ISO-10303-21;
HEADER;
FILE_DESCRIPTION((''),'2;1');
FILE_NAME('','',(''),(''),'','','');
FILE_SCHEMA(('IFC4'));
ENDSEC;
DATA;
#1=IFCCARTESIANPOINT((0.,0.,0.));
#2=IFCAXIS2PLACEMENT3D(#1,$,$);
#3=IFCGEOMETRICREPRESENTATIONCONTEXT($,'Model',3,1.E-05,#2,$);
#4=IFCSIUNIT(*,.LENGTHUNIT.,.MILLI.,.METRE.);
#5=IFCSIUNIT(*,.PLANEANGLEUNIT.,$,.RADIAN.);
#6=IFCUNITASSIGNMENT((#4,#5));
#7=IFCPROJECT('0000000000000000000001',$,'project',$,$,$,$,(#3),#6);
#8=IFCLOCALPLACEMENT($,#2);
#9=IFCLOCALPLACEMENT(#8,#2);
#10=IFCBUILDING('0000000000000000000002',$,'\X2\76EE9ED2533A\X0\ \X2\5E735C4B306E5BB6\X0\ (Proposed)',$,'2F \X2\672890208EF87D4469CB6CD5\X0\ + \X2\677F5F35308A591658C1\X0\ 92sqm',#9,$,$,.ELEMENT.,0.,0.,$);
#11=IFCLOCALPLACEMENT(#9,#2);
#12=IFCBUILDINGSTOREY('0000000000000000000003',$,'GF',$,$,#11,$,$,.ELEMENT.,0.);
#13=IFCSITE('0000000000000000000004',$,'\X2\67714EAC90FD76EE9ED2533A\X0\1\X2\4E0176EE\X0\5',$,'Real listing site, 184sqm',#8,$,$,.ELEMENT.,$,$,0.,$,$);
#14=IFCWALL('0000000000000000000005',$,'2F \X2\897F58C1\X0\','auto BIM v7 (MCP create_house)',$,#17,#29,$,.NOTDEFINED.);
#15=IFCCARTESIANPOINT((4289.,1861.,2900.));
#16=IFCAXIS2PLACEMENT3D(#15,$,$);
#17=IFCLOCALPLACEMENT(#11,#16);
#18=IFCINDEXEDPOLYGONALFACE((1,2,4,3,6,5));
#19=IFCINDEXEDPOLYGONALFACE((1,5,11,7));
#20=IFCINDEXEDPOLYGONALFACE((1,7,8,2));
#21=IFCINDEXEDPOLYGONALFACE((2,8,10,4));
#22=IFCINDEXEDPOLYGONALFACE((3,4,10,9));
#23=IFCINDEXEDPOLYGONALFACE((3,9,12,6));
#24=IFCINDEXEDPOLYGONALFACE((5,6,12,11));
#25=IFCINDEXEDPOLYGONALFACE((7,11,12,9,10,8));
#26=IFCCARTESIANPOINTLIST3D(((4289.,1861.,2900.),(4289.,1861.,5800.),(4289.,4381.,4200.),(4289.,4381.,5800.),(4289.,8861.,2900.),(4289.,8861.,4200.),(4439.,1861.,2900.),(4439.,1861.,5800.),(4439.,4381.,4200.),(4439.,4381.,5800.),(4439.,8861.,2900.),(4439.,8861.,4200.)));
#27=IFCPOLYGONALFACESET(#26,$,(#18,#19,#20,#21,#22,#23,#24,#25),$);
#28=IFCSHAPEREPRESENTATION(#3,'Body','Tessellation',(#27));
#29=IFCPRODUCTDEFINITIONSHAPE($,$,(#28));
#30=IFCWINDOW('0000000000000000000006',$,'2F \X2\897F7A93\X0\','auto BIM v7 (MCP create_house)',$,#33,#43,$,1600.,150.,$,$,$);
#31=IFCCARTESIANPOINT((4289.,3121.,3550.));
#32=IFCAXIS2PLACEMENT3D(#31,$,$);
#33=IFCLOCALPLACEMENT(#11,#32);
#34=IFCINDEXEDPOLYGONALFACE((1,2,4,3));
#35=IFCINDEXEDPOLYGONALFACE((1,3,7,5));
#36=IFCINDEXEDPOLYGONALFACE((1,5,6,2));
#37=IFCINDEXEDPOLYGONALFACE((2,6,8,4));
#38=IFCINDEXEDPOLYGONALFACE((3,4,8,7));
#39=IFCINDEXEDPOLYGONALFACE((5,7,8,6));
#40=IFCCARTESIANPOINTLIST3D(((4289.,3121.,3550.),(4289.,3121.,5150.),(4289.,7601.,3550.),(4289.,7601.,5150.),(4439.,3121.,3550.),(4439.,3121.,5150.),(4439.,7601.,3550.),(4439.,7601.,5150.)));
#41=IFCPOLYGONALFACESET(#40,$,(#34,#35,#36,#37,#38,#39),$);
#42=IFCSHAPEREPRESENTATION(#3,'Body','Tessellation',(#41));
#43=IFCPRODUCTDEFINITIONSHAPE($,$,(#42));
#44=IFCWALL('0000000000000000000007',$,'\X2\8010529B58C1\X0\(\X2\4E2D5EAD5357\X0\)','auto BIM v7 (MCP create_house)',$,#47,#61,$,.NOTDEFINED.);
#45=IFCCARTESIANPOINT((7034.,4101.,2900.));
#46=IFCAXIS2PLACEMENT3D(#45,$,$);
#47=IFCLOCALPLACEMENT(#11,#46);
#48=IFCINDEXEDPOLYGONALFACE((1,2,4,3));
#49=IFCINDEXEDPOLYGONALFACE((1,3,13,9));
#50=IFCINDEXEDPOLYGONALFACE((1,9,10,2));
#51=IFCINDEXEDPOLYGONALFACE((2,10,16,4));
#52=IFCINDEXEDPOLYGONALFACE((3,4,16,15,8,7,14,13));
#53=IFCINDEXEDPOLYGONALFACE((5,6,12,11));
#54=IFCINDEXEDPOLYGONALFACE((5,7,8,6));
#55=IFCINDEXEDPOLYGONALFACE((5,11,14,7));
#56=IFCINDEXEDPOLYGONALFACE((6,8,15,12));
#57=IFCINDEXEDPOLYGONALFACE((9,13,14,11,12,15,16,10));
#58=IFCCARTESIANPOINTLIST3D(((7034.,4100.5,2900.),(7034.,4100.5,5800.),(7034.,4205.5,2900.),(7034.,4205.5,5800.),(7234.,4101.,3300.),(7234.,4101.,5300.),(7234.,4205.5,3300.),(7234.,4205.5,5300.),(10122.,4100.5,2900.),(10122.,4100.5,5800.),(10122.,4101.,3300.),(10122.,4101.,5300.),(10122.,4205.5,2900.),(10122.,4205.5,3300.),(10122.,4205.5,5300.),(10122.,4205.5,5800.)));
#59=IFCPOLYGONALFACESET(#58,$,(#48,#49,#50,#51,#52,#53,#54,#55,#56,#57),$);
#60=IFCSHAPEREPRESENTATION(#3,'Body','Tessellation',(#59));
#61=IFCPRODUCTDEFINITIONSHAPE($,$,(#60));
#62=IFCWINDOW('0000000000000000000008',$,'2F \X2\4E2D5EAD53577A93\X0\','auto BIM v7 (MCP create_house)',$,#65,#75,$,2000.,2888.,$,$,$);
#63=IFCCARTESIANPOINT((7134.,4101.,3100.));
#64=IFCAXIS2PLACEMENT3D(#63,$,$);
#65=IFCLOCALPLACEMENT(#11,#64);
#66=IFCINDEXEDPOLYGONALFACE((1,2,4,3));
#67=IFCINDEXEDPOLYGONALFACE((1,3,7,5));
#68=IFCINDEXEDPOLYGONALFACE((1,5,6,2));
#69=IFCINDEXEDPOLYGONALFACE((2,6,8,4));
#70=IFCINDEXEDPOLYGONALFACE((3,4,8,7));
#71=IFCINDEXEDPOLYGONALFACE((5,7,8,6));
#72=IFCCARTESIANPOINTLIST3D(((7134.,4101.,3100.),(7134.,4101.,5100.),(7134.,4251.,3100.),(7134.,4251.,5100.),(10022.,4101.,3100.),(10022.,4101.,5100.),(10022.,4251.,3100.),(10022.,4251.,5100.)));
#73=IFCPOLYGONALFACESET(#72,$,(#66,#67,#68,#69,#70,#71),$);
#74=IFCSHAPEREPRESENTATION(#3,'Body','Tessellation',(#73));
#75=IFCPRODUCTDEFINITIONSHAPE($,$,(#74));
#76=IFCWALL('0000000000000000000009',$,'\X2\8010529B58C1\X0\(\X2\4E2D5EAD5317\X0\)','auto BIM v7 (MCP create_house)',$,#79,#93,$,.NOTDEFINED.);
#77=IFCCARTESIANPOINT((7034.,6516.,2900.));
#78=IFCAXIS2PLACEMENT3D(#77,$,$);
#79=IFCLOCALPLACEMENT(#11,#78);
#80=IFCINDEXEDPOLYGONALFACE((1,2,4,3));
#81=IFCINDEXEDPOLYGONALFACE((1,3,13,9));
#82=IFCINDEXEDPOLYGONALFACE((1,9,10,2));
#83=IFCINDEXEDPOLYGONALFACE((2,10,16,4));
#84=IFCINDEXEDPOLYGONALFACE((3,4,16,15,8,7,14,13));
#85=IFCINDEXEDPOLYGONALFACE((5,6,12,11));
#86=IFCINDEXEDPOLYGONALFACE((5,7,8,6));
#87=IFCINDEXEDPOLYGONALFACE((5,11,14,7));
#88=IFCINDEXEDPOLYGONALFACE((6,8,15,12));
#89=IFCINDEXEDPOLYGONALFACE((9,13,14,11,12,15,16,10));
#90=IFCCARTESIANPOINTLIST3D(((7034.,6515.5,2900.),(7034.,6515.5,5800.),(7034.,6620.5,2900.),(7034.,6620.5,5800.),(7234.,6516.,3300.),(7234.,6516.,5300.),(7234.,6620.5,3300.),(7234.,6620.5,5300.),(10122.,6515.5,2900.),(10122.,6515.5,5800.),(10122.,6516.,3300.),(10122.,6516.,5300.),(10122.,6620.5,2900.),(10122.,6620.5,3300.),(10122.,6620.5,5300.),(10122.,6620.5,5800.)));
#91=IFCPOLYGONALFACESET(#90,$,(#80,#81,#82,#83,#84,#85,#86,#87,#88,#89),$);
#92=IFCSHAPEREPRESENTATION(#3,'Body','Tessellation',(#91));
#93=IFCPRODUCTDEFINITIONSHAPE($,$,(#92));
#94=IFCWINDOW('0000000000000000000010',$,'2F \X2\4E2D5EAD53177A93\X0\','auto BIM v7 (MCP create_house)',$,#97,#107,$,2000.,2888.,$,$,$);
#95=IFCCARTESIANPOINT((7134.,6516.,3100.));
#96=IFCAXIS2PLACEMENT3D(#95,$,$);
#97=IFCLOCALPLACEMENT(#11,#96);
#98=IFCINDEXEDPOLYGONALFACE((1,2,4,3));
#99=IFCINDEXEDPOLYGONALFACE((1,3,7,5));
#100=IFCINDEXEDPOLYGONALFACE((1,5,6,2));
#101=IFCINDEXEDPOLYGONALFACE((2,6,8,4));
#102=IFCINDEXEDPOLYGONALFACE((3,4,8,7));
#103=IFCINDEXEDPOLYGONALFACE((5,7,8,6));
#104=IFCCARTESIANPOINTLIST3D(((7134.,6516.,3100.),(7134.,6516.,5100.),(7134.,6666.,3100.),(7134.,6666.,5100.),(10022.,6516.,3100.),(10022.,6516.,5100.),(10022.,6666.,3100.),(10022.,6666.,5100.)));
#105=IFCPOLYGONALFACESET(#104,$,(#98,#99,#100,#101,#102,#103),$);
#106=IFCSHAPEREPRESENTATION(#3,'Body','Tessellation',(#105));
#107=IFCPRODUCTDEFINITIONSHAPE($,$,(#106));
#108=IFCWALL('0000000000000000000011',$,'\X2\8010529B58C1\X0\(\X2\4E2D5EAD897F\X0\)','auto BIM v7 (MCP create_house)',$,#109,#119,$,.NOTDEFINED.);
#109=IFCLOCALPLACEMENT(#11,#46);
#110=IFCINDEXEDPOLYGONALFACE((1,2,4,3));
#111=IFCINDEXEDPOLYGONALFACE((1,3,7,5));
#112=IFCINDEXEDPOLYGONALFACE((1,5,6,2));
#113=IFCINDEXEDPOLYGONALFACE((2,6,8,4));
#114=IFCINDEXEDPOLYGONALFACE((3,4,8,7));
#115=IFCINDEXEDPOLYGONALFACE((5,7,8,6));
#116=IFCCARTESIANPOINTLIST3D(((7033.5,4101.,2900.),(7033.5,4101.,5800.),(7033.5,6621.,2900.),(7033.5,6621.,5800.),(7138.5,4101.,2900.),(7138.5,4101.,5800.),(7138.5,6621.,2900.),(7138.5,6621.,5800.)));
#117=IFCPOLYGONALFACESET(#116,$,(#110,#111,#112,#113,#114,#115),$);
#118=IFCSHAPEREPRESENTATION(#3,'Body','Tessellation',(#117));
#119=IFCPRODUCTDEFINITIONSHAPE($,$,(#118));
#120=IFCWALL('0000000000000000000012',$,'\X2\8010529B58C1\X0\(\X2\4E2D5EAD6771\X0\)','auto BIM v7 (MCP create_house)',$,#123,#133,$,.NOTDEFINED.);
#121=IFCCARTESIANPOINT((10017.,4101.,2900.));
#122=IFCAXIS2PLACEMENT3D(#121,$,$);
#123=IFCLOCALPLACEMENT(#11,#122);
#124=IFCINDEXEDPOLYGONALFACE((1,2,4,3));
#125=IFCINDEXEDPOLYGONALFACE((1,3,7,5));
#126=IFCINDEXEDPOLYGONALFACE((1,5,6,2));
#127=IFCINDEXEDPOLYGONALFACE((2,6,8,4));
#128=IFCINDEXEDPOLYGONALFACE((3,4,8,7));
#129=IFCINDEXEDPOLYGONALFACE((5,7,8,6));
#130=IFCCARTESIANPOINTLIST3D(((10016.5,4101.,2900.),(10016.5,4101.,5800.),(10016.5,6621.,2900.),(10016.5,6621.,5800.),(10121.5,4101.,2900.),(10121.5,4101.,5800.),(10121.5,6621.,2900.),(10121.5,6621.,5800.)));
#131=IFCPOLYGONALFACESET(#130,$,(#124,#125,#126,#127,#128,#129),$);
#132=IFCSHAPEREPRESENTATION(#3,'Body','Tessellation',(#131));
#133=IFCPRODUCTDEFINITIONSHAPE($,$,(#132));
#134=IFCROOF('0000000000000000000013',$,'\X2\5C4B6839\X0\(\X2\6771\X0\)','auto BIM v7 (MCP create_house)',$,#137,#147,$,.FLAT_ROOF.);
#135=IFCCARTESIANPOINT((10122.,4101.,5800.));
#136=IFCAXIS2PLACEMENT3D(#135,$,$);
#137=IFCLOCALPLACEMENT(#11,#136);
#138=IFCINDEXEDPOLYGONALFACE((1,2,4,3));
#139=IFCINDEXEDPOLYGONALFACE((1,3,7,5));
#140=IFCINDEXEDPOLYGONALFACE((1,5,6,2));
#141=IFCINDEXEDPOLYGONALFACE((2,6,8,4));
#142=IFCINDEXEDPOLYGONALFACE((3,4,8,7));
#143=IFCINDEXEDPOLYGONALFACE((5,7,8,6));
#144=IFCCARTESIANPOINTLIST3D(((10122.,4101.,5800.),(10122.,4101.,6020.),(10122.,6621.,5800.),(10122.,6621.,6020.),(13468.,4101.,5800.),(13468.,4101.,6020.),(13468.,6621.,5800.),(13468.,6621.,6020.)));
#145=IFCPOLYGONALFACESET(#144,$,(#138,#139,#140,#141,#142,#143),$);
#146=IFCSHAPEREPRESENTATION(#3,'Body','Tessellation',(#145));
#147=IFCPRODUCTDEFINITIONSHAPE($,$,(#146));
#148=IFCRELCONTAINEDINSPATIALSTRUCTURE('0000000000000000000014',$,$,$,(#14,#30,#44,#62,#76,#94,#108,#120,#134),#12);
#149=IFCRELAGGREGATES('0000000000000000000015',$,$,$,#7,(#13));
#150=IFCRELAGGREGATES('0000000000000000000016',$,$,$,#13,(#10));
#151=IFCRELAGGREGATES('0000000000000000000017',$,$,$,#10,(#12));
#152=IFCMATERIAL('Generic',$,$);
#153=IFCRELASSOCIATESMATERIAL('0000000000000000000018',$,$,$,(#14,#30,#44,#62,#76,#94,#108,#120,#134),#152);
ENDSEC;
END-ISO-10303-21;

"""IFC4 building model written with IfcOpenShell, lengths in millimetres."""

from ifc_helpers import new_model, si_unit, frame, frame_2d, origin, place, context, project, spatial, rectangle, extrude, material, element, fill, save


model = new_model("IFC4")

# Units and contexts
model_context = context("Model", 3, precision=1e-05, world=origin())
ifc_project = project(units=[si_unit("LENGTHUNIT", "METRE", prefix="MILLI"), si_unit("PLANEANGLEUNIT", "RADIAN")], contexts=[model_context])

# Site, building, storey
site_placement = place(None, origin())
site = spatial("IfcSite", under=ifc_project, at=site_placement, Name="東京都目黒区1丁目5", ObjectType="Real listing site, 184sqm", CompositionType="ELEMENT", RefElevation=0.0)
building_placement = place(site_placement, origin())
building = spatial("IfcBuilding", under=site, at=building_placement, Name="目黒区 平屋の家 (Proposed)", ObjectType="2F 木造軸組構法 + 板張り外壁 92sqm", CompositionType="ELEMENT", ElevationOfRefHeight=0.0, ElevationOfTerrain=0.0)
storey_placement = place(building_placement, origin())
storey = spatial("IfcBuildingStorey", under=building, at=storey_placement, Name="GF", CompositionType="ELEMENT", Elevation=0.0)

# Shared definitions
ifc_material = material(Name="Generic")

# Walls, openings, windows
wall_1_placement = place(storey_placement, frame((4289.0, 1861.0, 2900.0)))
wall_1 = element("IfcWall", 1, at=wall_1_placement, inside=storey, material=ifc_material, Name="2F 西壁", Description="auto BIM v7 (MCP create_house)", PredefinedType="NOTDEFINED", context=model_context, shape_type="SweptSolid", body=[
    extrude(rectangle(XDim=150.0, YDim=7000.0, at=frame_2d((75.0, 3500.0))), frame((4289.0, 1861.0, 2900.0)), (0.0, 0.0, 1.0), 2900.0),
])
opening_1_placement = place(storey_placement, frame((4289.0, 3121.0, 3550.0)))
opening_1 = element("IfcOpeningElement", 2, at=opening_1_placement, cuts=wall_1, PredefinedType="NOTDEFINED", context=model_context, shape_type="SweptSolid", body=[
    extrude(rectangle(XDim=150.0, YDim=4480.0, at=frame_2d((75.0, 2240.0))), frame((4289.0, 3121.0, 3550.0)), (0.0, 0.0, 1.0), 1600.0),
])
window_1_placement = place(storey_placement, frame((4289.0, 3121.0, 3550.0)))
window_1 = element("IfcWindow", 3, at=window_1_placement, inside=storey, material=ifc_material, Name="2F 西窓", Description="auto BIM v7 (MCP create_house)", OverallHeight=1600.0, OverallWidth=150.0, context=model_context, shape_type="SweptSolid", body=[
    extrude(rectangle(XDim=150.0, YDim=4480.0, at=frame_2d((75.0, 2240.0))), frame((4289.0, 3121.0, 3550.0)), (0.0, 0.0, 1.0), 1600.0),
])
fill(opening_1, window_1)
wall_2_placement = place(storey_placement, frame((7034.0, 4101.0, 2900.0)))
wall_2 = element("IfcWall", 4, at=wall_2_placement, inside=storey, material=ifc_material, Name="耐力壁(中庭南)", Description="auto BIM v7 (MCP create_house)", PredefinedType="NOTDEFINED", context=model_context, shape_type="SweptSolid", body=[
    extrude(rectangle(XDim=3088.0, YDim=105.0, at=frame_2d((1544.0, 52.0))), frame((7034.0, 4101.0, 2900.0)), (0.0, 0.0, 1.0), 2900.0),
])
opening_2_placement = place(storey_placement, frame((7134.0, 4101.0, 3100.0)))
opening_2 = element("IfcOpeningElement", 5, at=opening_2_placement, cuts=wall_2, PredefinedType="NOTDEFINED", context=model_context, shape_type="SweptSolid", body=[
    extrude(rectangle(XDim=2888.0, YDim=150.0, at=frame_2d((1444.0, 75.0))), frame((7134.0, 4101.0, 3100.0)), (0.0, 0.0, 1.0), 2000.0),
])
window_2_placement = place(storey_placement, frame((7134.0, 4101.0, 3100.0)))
window_2 = element("IfcWindow", 6, at=window_2_placement, inside=storey, material=ifc_material, Name="2F 中庭南窓", Description="auto BIM v7 (MCP create_house)", OverallHeight=2000.0, OverallWidth=2888.0, context=model_context, shape_type="SweptSolid", body=[
    extrude(rectangle(XDim=2888.0, YDim=150.0, at=frame_2d((1444.0, 75.0))), frame((7134.0, 4101.0, 3100.0)), (0.0, 0.0, 1.0), 2000.0),
])
fill(opening_2, window_2)
wall_3_placement = place(storey_placement, frame((7034.0, 6516.0, 2900.0)))
wall_3 = element("IfcWall", 7, at=wall_3_placement, inside=storey, material=ifc_material, Name="耐力壁(中庭北)", Description="auto BIM v7 (MCP create_house)", PredefinedType="NOTDEFINED", context=model_context, shape_type="SweptSolid", body=[
    extrude(rectangle(XDim=3088.0, YDim=105.0, at=frame_2d((1544.0, 52.0))), frame((7034.0, 6516.0, 2900.0)), (0.0, 0.0, 1.0), 2900.0),
])
opening_3_placement = place(storey_placement, frame((7134.0, 6516.0, 3100.0)))
opening_3 = element("IfcOpeningElement", 8, at=opening_3_placement, cuts=wall_3, PredefinedType="NOTDEFINED", context=model_context, shape_type="SweptSolid", body=[
    extrude(rectangle(XDim=2888.0, YDim=150.0, at=frame_2d((1444.0, 75.0))), frame((7134.0, 6516.0, 3100.0)), (0.0, 0.0, 1.0), 2000.0),
])
window_3_placement = place(storey_placement, frame((7134.0, 6516.0, 3100.0)))
window_3 = element("IfcWindow", 9, at=window_3_placement, inside=storey, material=ifc_material, Name="2F 中庭北窓", Description="auto BIM v7 (MCP create_house)", OverallHeight=2000.0, OverallWidth=2888.0, context=model_context, shape_type="SweptSolid", body=[
    extrude(rectangle(XDim=2888.0, YDim=150.0, at=frame_2d((1444.0, 75.0))), frame((7134.0, 6516.0, 3100.0)), (0.0, 0.0, 1.0), 2000.0),
])
fill(opening_3, window_3)

# Walls
wall_4_placement = place(storey_placement, frame((7034.0, 4101.0, 2900.0)))
element("IfcWall", 10, at=wall_4_placement, inside=storey, material=ifc_material, Name="耐力壁(中庭西)", Description="auto BIM v7 (MCP create_house)", PredefinedType="NOTDEFINED", context=model_context, shape_type="SweptSolid", body=[
    extrude(rectangle(XDim=105.0, YDim=2520.0, at=frame_2d((52.0, 1260.0))), frame((7034.0, 4101.0, 2900.0)), (0.0, 0.0, 1.0), 2900.0),
])
wall_5_placement = place(storey_placement, frame((10017.0, 4101.0, 2900.0)))
element("IfcWall", 11, at=wall_5_placement, inside=storey, material=ifc_material, Name="耐力壁(中庭東)", Description="auto BIM v7 (MCP create_house)", PredefinedType="NOTDEFINED", context=model_context, shape_type="SweptSolid", body=[
    extrude(rectangle(XDim=105.0, YDim=2520.0, at=frame_2d((52.0, 1260.0))), frame((10017.0, 4101.0, 2900.0)), (0.0, 0.0, 1.0), 2900.0),
])

# Roof
for number, where, name in (
    (12, (10122.0, 4101.0, 5800.0), "屋根(東)"),
):
    element("IfcRoof", number, at=place(storey_placement, frame(where)), inside=storey, material=ifc_material, Name=name, Description="auto BIM v7 (MCP create_house)", PredefinedType="FLAT_ROOF", context=model_context, shape_type="SweptSolid", body=[
        extrude(rectangle(XDim=3346.0, YDim=2520.0, at=frame_2d((1673.0, 1260.0))), frame((10122.0, 4101.0, 5800.0)), (0.0, 0.0, 1.0), 220.0),
    ])

save(model, "model.ifc")
